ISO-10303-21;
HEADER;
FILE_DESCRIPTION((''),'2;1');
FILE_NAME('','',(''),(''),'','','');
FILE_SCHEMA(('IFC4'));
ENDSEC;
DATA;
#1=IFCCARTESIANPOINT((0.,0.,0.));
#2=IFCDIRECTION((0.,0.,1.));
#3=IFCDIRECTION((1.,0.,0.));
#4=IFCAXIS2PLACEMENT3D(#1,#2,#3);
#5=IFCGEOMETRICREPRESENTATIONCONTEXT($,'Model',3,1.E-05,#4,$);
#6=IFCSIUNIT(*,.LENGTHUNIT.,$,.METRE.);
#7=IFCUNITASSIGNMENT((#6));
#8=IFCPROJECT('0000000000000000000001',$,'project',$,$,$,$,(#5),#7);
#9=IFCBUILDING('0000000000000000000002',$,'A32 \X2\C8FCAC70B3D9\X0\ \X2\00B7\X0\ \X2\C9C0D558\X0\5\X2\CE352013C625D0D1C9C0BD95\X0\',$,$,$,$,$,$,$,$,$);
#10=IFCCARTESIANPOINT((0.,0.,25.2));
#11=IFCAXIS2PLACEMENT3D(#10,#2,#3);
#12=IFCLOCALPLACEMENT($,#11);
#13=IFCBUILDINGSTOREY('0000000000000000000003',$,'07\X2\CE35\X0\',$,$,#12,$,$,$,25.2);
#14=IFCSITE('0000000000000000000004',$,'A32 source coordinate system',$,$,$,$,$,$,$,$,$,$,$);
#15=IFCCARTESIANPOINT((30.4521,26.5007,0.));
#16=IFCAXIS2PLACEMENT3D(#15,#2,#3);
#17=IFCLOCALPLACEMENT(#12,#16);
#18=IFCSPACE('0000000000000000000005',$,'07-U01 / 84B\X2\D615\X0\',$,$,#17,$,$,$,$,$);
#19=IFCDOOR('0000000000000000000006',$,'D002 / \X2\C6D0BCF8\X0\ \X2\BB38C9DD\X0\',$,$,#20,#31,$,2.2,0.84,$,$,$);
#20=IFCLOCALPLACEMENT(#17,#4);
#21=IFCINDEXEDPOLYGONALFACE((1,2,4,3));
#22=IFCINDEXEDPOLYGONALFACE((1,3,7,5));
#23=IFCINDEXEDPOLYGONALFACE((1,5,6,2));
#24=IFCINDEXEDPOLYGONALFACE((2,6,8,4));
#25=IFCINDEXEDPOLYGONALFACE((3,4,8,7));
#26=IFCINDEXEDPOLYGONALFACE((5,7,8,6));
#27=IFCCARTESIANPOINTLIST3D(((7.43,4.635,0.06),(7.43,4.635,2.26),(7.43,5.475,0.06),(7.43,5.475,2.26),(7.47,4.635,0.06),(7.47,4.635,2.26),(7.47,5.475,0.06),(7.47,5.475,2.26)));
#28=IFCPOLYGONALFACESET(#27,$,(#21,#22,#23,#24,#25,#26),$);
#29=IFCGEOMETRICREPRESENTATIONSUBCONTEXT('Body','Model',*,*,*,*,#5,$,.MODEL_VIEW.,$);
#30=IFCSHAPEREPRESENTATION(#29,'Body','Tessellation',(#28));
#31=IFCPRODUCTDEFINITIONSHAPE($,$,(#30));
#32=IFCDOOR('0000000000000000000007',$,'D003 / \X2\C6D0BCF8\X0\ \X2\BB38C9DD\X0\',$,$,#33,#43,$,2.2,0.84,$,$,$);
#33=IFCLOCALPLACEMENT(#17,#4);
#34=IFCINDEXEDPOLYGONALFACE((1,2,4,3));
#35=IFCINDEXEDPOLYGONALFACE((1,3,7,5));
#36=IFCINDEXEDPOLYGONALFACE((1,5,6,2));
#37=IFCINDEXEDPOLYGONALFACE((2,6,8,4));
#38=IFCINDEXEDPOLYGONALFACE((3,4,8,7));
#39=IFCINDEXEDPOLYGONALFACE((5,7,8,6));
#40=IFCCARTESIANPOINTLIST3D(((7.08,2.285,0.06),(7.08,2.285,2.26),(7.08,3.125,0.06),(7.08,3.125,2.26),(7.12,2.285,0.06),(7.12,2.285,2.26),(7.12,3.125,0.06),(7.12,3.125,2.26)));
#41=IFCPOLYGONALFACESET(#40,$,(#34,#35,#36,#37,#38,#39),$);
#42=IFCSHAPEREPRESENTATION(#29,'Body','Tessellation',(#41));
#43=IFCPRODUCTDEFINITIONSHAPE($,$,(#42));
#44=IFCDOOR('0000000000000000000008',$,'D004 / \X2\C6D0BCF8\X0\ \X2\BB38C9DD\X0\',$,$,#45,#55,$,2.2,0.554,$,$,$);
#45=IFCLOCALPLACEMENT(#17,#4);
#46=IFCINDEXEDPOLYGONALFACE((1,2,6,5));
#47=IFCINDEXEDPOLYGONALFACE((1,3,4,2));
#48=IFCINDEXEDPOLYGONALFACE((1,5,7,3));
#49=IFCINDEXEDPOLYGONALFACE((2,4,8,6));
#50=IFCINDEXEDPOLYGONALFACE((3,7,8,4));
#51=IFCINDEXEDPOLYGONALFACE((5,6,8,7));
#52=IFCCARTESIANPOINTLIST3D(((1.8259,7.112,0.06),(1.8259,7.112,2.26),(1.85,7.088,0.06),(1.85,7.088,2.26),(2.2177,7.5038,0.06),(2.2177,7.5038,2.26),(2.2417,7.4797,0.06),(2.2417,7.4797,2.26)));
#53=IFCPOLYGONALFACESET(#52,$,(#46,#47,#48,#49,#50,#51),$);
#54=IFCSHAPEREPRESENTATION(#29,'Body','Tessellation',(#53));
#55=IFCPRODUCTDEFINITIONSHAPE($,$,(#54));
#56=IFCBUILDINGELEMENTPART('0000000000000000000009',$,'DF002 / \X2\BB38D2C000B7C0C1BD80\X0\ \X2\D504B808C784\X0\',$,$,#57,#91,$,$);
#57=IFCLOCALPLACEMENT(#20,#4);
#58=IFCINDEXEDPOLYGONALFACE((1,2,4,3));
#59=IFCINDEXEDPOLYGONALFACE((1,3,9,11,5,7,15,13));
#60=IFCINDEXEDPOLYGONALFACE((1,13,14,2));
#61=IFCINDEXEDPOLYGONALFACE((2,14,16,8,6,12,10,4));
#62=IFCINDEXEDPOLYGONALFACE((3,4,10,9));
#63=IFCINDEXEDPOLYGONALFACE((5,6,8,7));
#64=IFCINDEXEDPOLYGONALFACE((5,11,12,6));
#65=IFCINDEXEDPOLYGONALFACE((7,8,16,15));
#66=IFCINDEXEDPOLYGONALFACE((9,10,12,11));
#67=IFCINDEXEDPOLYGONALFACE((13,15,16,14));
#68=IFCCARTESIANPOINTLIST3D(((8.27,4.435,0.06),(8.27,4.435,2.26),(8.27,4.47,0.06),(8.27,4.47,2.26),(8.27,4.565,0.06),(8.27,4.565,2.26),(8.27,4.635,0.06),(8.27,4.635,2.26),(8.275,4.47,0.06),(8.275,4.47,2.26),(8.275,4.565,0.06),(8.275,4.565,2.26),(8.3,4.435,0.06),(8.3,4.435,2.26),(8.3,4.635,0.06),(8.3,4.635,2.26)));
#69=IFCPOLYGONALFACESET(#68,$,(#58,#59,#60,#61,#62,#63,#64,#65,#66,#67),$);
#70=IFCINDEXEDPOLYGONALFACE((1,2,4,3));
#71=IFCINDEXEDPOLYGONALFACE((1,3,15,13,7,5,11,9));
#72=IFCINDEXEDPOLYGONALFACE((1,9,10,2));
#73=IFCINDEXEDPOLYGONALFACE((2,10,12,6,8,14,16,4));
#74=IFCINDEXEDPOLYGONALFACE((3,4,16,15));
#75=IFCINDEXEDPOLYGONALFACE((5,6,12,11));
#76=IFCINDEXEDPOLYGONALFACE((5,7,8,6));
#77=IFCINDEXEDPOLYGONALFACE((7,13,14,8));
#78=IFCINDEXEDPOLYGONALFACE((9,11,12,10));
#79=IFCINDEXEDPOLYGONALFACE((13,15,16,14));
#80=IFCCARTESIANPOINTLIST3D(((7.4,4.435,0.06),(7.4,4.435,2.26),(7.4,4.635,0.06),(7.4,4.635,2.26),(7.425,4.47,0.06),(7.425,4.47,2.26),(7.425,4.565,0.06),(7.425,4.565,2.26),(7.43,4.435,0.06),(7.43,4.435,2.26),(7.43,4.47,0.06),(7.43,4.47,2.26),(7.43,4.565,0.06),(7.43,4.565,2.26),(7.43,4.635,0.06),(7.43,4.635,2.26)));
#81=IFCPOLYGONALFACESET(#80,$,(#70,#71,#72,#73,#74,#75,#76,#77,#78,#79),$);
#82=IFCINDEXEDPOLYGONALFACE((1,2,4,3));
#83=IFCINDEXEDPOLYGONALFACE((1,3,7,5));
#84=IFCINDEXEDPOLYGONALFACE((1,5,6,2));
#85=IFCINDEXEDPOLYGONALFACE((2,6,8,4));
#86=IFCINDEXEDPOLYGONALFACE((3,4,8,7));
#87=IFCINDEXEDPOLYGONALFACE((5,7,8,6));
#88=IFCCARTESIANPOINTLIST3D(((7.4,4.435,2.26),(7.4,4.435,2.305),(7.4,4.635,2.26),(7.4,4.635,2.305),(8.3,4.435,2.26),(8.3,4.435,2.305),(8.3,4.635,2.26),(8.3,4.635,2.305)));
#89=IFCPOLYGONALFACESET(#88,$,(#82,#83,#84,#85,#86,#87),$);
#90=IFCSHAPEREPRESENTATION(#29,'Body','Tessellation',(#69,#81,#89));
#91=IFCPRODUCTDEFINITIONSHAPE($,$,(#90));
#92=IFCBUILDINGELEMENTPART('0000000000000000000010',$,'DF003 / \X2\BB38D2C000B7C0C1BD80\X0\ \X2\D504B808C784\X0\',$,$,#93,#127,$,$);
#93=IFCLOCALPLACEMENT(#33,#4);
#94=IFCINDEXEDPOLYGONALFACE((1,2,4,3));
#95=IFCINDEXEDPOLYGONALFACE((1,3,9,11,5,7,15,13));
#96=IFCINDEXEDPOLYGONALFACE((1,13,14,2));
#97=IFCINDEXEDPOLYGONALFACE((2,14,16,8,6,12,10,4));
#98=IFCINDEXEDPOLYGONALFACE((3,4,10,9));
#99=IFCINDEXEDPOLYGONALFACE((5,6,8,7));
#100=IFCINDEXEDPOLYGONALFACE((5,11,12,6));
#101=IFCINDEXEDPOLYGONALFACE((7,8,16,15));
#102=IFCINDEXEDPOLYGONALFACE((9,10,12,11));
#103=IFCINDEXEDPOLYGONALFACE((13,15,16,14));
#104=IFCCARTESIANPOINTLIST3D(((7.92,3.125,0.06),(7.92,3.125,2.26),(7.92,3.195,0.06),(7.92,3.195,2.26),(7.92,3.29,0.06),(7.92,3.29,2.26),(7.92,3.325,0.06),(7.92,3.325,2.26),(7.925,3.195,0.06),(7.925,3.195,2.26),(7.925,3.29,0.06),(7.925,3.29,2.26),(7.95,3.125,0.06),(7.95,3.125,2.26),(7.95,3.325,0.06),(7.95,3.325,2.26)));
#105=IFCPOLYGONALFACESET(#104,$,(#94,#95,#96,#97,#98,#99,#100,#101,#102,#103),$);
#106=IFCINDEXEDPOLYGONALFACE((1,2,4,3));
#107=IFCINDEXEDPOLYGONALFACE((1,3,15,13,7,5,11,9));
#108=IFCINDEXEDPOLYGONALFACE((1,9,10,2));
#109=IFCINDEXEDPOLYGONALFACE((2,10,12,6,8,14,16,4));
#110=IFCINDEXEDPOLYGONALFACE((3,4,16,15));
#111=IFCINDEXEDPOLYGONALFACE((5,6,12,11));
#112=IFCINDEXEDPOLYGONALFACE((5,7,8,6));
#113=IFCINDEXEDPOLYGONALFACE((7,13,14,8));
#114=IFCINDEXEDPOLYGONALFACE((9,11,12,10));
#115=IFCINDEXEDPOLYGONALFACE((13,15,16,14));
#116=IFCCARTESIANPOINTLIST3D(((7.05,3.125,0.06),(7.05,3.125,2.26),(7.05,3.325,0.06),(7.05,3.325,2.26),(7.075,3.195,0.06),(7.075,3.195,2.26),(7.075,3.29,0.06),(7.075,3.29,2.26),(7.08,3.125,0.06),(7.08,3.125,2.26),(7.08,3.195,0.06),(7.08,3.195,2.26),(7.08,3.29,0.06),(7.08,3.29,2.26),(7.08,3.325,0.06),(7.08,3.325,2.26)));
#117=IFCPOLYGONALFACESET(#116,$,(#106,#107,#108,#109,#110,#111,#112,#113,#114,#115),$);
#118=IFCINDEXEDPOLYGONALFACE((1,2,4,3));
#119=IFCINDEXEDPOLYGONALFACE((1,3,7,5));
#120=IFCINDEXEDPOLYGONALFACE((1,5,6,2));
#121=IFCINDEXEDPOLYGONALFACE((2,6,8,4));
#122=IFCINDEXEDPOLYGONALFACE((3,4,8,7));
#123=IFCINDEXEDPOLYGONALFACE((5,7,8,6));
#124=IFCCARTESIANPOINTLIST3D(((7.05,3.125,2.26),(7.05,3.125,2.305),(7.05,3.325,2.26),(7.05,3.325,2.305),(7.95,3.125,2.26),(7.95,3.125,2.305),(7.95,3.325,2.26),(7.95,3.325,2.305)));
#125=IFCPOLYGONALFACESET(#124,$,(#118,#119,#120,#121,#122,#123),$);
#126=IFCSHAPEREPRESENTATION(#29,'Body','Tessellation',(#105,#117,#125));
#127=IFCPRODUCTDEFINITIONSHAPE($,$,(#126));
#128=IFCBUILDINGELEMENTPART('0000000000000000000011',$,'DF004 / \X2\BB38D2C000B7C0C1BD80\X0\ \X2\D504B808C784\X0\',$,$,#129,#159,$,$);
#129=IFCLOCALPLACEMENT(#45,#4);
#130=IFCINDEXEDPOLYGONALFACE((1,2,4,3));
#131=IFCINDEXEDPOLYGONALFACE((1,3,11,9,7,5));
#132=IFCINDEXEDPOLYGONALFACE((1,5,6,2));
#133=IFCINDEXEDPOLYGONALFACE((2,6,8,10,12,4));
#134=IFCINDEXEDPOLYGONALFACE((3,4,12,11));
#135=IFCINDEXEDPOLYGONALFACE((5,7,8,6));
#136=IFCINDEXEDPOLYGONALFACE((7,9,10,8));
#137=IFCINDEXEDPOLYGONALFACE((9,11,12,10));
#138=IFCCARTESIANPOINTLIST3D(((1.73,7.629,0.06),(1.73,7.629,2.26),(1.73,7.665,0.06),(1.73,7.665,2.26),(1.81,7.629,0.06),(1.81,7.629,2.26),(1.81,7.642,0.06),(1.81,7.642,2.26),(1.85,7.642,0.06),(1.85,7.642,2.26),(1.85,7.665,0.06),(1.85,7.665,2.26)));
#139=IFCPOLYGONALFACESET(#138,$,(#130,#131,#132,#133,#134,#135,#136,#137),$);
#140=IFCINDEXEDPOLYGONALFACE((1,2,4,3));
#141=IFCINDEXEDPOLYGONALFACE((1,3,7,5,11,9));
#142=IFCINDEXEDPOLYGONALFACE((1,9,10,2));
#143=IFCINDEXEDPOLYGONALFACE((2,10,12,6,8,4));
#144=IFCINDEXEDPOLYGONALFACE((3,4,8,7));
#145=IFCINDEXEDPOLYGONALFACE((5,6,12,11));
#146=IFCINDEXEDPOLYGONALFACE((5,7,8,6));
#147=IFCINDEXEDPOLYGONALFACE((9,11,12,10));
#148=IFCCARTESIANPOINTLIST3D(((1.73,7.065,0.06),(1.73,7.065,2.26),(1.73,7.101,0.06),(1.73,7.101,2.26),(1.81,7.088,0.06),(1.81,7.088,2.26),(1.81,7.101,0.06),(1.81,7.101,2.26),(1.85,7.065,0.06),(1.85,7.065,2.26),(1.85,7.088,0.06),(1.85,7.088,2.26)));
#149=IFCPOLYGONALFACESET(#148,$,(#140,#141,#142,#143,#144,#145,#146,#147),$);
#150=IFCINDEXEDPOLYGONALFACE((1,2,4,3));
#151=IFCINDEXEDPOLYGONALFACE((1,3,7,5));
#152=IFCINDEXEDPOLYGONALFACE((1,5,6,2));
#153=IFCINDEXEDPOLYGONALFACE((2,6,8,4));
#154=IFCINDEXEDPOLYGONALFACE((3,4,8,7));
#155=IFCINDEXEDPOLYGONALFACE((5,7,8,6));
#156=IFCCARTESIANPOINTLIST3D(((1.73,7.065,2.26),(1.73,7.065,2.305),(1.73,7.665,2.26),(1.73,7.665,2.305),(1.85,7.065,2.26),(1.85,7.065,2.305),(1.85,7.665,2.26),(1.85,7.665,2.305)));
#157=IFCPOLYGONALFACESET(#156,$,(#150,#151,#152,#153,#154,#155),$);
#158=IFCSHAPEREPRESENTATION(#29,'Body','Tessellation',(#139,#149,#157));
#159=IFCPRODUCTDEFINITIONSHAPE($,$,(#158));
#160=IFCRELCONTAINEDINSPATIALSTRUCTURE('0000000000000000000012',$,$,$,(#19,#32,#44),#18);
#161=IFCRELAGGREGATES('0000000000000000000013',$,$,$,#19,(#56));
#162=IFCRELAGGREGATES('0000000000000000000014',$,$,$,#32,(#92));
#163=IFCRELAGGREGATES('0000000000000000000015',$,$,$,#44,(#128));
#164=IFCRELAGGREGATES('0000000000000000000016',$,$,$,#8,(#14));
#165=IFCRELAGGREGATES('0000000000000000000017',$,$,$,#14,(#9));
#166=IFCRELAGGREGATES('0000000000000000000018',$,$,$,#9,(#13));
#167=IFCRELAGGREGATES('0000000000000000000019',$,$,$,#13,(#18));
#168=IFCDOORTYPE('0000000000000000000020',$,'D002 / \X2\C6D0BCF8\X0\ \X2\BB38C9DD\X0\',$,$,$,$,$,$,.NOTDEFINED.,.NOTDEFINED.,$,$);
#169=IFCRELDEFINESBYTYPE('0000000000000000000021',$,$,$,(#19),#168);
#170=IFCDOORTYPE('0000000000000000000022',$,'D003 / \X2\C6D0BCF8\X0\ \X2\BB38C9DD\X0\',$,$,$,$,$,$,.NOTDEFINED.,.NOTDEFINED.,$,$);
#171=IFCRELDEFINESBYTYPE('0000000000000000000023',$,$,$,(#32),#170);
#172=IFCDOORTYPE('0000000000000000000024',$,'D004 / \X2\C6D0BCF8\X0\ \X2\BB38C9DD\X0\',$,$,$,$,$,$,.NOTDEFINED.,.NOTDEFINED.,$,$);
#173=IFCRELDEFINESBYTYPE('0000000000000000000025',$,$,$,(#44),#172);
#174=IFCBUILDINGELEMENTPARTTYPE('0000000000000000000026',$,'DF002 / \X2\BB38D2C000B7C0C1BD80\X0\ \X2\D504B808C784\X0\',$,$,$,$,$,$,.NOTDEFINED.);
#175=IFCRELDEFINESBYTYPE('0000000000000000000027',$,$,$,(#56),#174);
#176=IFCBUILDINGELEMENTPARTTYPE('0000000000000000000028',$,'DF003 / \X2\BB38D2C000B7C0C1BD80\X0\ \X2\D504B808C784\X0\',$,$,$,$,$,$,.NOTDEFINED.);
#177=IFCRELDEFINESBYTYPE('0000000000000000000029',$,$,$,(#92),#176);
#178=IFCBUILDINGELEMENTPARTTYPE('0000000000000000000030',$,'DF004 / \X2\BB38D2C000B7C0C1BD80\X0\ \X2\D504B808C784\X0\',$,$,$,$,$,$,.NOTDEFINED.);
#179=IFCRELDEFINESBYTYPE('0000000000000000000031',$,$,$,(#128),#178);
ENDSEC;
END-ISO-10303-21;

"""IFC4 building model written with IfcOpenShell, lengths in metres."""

from ifc_helpers import new_model, si_unit, frame, origin, origin_with_axes, place, context, subcontext, project, spatial, polyline, outline, extrude, source, transform, mapped, type_object, type_shapes, element, aggregate, save


model = new_model("IFC4")

# Units and contexts
model_context = context("Model", 3, precision=1e-05, world=origin_with_axes())
body_context = subcontext(model_context, "Body", "Model", "MODEL_VIEW")
ifc_project = project(units=[si_unit("LENGTHUNIT", "METRE")], contexts=[model_context])

# Site, building, storey, space
storey_placement = place(None, frame((0.0, 0.0, 25.2), z_axis=(0.0, 0.0, 1.0), x_axis=(1.0, 0.0, 0.0)))
space_placement = place(storey_placement, frame((30.4521, 26.5007, 0.0), z_axis=(0.0, 0.0, 1.0), x_axis=(1.0, 0.0, 0.0)))
site = spatial("IfcSite", under=ifc_project, Name="A32 source coordinate system")
building = spatial("IfcBuilding", under=site, Name="A32 주거동 · 지하5층–옥탑지붕")
storey = spatial("IfcBuildingStorey", under=building, at=storey_placement, Name="07층", Elevation=25.2)
space = spatial("IfcSpace", under=storey, at=space_placement, Name="07-U01 / 84B형")

# Doors
door_type_1 = type_object("IfcDoorType", Name="D002 / 원본 문짝", OperationType="NOTDEFINED", PredefinedType="NOTDEFINED")
shared_shape_1 = source(origin(), body_context, "Body", "SweptSolid", [
    extrude(outline(polyline([(7.43, 4.635), (7.43, 5.475), (7.47, 5.475), (7.47, 4.635), (7.43, 4.635)])), frame((0.0, 0.0, 0.06)), (0.0, 0.0, 1.0), 2.2),
])
type_shapes(door_type_1, [shared_shape_1])
door_1_placement = place(space_placement, origin_with_axes())
door_1 = element("IfcDoor", 1, at=door_1_placement, inside=space, type_object=door_type_1, Name="D002 / 원본 문짝", OverallHeight=2.2, OverallWidth=0.84, context=body_context, shape_type="MappedRepresentation", body=[
    mapped(shared_shape_1, transform((0.0, 0.0, 0.0), scale=1.0)),
])
door_type_2 = type_object("IfcDoorType", Name="D003 / 원본 문짝", OperationType="NOTDEFINED", PredefinedType="NOTDEFINED")
shared_shape_2 = source(origin(), body_context, "Body", "SweptSolid", [
    extrude(outline(polyline([(7.12, 2.285), (7.08, 2.285), (7.08, 3.125), (7.12, 3.125), (7.12, 2.285)])), frame((0.0, 0.0, 0.06)), (0.0, 0.0, 1.0), 2.2),
])
type_shapes(door_type_2, [shared_shape_2])
door_2_placement = place(space_placement, origin_with_axes())
door_2 = element("IfcDoor", 2, at=door_2_placement, inside=space, type_object=door_type_2, Name="D003 / 원본 문짝", OverallHeight=2.2, OverallWidth=0.84, context=body_context, shape_type="MappedRepresentation", body=[
    mapped(shared_shape_2, transform((0.0, 0.0, 0.0), scale=1.0)),
])
door_type_3 = type_object("IfcDoorType", Name="D004 / 원본 문짝", OperationType="NOTDEFINED", PredefinedType="NOTDEFINED")
shared_shape_3 = source(origin(), body_context, "Body", "SweptSolid", [
    extrude(outline(polyline([(2.2177, 7.5038), (2.2417, 7.4797), (1.85, 7.088), (1.8259, 7.112), (2.2177, 7.5038)])), frame((0.0, 0.0, 0.06)), (0.0, 0.0, 1.0), 2.2),
])
type_shapes(door_type_3, [shared_shape_3])
door_3_placement = place(space_placement, origin_with_axes())
door_3 = element("IfcDoor", 3, at=door_3_placement, inside=space, type_object=door_type_3, Name="D004 / 원본 문짝", OverallHeight=2.2, OverallWidth=0.554, context=body_context, shape_type="MappedRepresentation", body=[
    mapped(shared_shape_3, transform((0.0, 0.0, 0.0), scale=1.0)),
])

# Building element parts
building_element_part_type_1 = type_object("IfcBuildingElementPartType", Name="DF002 / 문틀·상부 프레임", PredefinedType="NOTDEFINED")
shared_shape_4 = source(origin(), body_context, "Body", "SweptSolid", [
    extrude(outline(polyline([(8.3, 4.435), (8.27, 4.435), (8.27, 4.47), (8.275, 4.47), (8.275, 4.565), (8.27, 4.565), (8.27, 4.635), (8.3, 4.635), (8.3, 4.435)])), frame((0.0, 0.0, 0.06)), (0.0, 0.0, 1.0), 2.2),
    extrude(outline(polyline([(7.43, 4.635), (7.43, 4.565), (7.425, 4.565), (7.425, 4.47), (7.43, 4.47), (7.43, 4.435), (7.4, 4.435), (7.4, 4.635), (7.43, 4.635)])), frame((0.0, 0.0, 0.06)), (0.0, 0.0, 1.0), 2.2),
    extrude(outline(polyline([(7.4, 4.435), (7.4, 4.635), (8.3, 4.635), (8.3, 4.435), (7.4, 4.435)])), frame((0.0, 0.0, 2.26)), (0.0, 0.0, 1.0), 0.045),
])
type_shapes(building_element_part_type_1, [shared_shape_4])
building_element_part_1_placement = place(door_1_placement, origin_with_axes())
building_element_part_1 = element("IfcBuildingElementPart", 4, at=building_element_part_1_placement, type_object=building_element_part_type_1, Name="DF002 / 문틀·상부 프레임", context=body_context, shape_type="MappedRepresentation", body=[
    mapped(shared_shape_4, transform((0.0, 0.0, 0.0), scale=1.0)),
])
aggregate(door_1, [building_element_part_1])
building_element_part_type_2 = type_object("IfcBuildingElementPartType", Name="DF003 / 문틀·상부 프레임", PredefinedType="NOTDEFINED")
shared_shape_5 = source(origin(), body_context, "Body", "SweptSolid", [
    extrude(outline(polyline([(7.92, 3.125), (7.92, 3.195), (7.925, 3.195), (7.925, 3.29), (7.92, 3.29), (7.92, 3.325), (7.95, 3.325), (7.95, 3.125), (7.92, 3.125)])), frame((0.0, 0.0, 0.06)), (0.0, 0.0, 1.0), 2.2),
    extrude(outline(polyline([(7.05, 3.325), (7.08, 3.325), (7.08, 3.29), (7.075, 3.29), (7.075, 3.195), (7.08, 3.195), (7.08, 3.125), (7.05, 3.125), (7.05, 3.325)])), frame((0.0, 0.0, 0.06)), (0.0, 0.0, 1.0), 2.2),
    extrude(outline(polyline([(7.05, 3.125), (7.05, 3.325), (7.95, 3.325), (7.95, 3.125), (7.05, 3.125)])), frame((0.0, 0.0, 2.26)), (0.0, 0.0, 1.0), 0.045),
])
type_shapes(building_element_part_type_2, [shared_shape_5])
building_element_part_2_placement = place(door_2_placement, origin_with_axes())
building_element_part_2 = element("IfcBuildingElementPart", 5, at=building_element_part_2_placement, type_object=building_element_part_type_2, Name="DF003 / 문틀·상부 프레임", context=body_context, shape_type="MappedRepresentation", body=[
    mapped(shared_shape_5, transform((0.0, 0.0, 0.0), scale=1.0)),
])
aggregate(door_2, [building_element_part_2])
building_element_part_type_3 = type_object("IfcBuildingElementPartType", Name="DF004 / 문틀·상부 프레임", PredefinedType="NOTDEFINED")
shared_shape_6 = source(origin(), body_context, "Body", "SweptSolid", [
    extrude(outline(polyline([(1.85, 7.665), (1.85, 7.642), (1.81, 7.642), (1.81, 7.629), (1.73, 7.629), (1.73, 7.665), (1.85, 7.665)])), frame((0.0, 0.0, 0.06)), (0.0, 0.0, 1.0), 2.2),
    extrude(outline(polyline([(1.73, 7.101), (1.81, 7.101), (1.81, 7.088), (1.85, 7.088), (1.85, 7.065), (1.73, 7.065), (1.73, 7.101)])), frame((0.0, 0.0, 0.06)), (0.0, 0.0, 1.0), 2.2),
    extrude(outline(polyline([(1.73, 7.065), (1.73, 7.665), (1.85, 7.665), (1.85, 7.065), (1.73, 7.065)])), frame((0.0, 0.0, 2.26)), (0.0, 0.0, 1.0), 0.045),
])
type_shapes(building_element_part_type_3, [shared_shape_6])
building_element_part_3_placement = place(door_3_placement, origin_with_axes())
building_element_part_3 = element("IfcBuildingElementPart", 6, at=building_element_part_3_placement, type_object=building_element_part_type_3, Name="DF004 / 문틀·상부 프레임", context=body_context, shape_type="MappedRepresentation", body=[
    mapped(shared_shape_6, transform((0.0, 0.0, 0.0), scale=1.0)),
])
aggregate(door_3, [building_element_part_3])

save(model, "model.ifc")
